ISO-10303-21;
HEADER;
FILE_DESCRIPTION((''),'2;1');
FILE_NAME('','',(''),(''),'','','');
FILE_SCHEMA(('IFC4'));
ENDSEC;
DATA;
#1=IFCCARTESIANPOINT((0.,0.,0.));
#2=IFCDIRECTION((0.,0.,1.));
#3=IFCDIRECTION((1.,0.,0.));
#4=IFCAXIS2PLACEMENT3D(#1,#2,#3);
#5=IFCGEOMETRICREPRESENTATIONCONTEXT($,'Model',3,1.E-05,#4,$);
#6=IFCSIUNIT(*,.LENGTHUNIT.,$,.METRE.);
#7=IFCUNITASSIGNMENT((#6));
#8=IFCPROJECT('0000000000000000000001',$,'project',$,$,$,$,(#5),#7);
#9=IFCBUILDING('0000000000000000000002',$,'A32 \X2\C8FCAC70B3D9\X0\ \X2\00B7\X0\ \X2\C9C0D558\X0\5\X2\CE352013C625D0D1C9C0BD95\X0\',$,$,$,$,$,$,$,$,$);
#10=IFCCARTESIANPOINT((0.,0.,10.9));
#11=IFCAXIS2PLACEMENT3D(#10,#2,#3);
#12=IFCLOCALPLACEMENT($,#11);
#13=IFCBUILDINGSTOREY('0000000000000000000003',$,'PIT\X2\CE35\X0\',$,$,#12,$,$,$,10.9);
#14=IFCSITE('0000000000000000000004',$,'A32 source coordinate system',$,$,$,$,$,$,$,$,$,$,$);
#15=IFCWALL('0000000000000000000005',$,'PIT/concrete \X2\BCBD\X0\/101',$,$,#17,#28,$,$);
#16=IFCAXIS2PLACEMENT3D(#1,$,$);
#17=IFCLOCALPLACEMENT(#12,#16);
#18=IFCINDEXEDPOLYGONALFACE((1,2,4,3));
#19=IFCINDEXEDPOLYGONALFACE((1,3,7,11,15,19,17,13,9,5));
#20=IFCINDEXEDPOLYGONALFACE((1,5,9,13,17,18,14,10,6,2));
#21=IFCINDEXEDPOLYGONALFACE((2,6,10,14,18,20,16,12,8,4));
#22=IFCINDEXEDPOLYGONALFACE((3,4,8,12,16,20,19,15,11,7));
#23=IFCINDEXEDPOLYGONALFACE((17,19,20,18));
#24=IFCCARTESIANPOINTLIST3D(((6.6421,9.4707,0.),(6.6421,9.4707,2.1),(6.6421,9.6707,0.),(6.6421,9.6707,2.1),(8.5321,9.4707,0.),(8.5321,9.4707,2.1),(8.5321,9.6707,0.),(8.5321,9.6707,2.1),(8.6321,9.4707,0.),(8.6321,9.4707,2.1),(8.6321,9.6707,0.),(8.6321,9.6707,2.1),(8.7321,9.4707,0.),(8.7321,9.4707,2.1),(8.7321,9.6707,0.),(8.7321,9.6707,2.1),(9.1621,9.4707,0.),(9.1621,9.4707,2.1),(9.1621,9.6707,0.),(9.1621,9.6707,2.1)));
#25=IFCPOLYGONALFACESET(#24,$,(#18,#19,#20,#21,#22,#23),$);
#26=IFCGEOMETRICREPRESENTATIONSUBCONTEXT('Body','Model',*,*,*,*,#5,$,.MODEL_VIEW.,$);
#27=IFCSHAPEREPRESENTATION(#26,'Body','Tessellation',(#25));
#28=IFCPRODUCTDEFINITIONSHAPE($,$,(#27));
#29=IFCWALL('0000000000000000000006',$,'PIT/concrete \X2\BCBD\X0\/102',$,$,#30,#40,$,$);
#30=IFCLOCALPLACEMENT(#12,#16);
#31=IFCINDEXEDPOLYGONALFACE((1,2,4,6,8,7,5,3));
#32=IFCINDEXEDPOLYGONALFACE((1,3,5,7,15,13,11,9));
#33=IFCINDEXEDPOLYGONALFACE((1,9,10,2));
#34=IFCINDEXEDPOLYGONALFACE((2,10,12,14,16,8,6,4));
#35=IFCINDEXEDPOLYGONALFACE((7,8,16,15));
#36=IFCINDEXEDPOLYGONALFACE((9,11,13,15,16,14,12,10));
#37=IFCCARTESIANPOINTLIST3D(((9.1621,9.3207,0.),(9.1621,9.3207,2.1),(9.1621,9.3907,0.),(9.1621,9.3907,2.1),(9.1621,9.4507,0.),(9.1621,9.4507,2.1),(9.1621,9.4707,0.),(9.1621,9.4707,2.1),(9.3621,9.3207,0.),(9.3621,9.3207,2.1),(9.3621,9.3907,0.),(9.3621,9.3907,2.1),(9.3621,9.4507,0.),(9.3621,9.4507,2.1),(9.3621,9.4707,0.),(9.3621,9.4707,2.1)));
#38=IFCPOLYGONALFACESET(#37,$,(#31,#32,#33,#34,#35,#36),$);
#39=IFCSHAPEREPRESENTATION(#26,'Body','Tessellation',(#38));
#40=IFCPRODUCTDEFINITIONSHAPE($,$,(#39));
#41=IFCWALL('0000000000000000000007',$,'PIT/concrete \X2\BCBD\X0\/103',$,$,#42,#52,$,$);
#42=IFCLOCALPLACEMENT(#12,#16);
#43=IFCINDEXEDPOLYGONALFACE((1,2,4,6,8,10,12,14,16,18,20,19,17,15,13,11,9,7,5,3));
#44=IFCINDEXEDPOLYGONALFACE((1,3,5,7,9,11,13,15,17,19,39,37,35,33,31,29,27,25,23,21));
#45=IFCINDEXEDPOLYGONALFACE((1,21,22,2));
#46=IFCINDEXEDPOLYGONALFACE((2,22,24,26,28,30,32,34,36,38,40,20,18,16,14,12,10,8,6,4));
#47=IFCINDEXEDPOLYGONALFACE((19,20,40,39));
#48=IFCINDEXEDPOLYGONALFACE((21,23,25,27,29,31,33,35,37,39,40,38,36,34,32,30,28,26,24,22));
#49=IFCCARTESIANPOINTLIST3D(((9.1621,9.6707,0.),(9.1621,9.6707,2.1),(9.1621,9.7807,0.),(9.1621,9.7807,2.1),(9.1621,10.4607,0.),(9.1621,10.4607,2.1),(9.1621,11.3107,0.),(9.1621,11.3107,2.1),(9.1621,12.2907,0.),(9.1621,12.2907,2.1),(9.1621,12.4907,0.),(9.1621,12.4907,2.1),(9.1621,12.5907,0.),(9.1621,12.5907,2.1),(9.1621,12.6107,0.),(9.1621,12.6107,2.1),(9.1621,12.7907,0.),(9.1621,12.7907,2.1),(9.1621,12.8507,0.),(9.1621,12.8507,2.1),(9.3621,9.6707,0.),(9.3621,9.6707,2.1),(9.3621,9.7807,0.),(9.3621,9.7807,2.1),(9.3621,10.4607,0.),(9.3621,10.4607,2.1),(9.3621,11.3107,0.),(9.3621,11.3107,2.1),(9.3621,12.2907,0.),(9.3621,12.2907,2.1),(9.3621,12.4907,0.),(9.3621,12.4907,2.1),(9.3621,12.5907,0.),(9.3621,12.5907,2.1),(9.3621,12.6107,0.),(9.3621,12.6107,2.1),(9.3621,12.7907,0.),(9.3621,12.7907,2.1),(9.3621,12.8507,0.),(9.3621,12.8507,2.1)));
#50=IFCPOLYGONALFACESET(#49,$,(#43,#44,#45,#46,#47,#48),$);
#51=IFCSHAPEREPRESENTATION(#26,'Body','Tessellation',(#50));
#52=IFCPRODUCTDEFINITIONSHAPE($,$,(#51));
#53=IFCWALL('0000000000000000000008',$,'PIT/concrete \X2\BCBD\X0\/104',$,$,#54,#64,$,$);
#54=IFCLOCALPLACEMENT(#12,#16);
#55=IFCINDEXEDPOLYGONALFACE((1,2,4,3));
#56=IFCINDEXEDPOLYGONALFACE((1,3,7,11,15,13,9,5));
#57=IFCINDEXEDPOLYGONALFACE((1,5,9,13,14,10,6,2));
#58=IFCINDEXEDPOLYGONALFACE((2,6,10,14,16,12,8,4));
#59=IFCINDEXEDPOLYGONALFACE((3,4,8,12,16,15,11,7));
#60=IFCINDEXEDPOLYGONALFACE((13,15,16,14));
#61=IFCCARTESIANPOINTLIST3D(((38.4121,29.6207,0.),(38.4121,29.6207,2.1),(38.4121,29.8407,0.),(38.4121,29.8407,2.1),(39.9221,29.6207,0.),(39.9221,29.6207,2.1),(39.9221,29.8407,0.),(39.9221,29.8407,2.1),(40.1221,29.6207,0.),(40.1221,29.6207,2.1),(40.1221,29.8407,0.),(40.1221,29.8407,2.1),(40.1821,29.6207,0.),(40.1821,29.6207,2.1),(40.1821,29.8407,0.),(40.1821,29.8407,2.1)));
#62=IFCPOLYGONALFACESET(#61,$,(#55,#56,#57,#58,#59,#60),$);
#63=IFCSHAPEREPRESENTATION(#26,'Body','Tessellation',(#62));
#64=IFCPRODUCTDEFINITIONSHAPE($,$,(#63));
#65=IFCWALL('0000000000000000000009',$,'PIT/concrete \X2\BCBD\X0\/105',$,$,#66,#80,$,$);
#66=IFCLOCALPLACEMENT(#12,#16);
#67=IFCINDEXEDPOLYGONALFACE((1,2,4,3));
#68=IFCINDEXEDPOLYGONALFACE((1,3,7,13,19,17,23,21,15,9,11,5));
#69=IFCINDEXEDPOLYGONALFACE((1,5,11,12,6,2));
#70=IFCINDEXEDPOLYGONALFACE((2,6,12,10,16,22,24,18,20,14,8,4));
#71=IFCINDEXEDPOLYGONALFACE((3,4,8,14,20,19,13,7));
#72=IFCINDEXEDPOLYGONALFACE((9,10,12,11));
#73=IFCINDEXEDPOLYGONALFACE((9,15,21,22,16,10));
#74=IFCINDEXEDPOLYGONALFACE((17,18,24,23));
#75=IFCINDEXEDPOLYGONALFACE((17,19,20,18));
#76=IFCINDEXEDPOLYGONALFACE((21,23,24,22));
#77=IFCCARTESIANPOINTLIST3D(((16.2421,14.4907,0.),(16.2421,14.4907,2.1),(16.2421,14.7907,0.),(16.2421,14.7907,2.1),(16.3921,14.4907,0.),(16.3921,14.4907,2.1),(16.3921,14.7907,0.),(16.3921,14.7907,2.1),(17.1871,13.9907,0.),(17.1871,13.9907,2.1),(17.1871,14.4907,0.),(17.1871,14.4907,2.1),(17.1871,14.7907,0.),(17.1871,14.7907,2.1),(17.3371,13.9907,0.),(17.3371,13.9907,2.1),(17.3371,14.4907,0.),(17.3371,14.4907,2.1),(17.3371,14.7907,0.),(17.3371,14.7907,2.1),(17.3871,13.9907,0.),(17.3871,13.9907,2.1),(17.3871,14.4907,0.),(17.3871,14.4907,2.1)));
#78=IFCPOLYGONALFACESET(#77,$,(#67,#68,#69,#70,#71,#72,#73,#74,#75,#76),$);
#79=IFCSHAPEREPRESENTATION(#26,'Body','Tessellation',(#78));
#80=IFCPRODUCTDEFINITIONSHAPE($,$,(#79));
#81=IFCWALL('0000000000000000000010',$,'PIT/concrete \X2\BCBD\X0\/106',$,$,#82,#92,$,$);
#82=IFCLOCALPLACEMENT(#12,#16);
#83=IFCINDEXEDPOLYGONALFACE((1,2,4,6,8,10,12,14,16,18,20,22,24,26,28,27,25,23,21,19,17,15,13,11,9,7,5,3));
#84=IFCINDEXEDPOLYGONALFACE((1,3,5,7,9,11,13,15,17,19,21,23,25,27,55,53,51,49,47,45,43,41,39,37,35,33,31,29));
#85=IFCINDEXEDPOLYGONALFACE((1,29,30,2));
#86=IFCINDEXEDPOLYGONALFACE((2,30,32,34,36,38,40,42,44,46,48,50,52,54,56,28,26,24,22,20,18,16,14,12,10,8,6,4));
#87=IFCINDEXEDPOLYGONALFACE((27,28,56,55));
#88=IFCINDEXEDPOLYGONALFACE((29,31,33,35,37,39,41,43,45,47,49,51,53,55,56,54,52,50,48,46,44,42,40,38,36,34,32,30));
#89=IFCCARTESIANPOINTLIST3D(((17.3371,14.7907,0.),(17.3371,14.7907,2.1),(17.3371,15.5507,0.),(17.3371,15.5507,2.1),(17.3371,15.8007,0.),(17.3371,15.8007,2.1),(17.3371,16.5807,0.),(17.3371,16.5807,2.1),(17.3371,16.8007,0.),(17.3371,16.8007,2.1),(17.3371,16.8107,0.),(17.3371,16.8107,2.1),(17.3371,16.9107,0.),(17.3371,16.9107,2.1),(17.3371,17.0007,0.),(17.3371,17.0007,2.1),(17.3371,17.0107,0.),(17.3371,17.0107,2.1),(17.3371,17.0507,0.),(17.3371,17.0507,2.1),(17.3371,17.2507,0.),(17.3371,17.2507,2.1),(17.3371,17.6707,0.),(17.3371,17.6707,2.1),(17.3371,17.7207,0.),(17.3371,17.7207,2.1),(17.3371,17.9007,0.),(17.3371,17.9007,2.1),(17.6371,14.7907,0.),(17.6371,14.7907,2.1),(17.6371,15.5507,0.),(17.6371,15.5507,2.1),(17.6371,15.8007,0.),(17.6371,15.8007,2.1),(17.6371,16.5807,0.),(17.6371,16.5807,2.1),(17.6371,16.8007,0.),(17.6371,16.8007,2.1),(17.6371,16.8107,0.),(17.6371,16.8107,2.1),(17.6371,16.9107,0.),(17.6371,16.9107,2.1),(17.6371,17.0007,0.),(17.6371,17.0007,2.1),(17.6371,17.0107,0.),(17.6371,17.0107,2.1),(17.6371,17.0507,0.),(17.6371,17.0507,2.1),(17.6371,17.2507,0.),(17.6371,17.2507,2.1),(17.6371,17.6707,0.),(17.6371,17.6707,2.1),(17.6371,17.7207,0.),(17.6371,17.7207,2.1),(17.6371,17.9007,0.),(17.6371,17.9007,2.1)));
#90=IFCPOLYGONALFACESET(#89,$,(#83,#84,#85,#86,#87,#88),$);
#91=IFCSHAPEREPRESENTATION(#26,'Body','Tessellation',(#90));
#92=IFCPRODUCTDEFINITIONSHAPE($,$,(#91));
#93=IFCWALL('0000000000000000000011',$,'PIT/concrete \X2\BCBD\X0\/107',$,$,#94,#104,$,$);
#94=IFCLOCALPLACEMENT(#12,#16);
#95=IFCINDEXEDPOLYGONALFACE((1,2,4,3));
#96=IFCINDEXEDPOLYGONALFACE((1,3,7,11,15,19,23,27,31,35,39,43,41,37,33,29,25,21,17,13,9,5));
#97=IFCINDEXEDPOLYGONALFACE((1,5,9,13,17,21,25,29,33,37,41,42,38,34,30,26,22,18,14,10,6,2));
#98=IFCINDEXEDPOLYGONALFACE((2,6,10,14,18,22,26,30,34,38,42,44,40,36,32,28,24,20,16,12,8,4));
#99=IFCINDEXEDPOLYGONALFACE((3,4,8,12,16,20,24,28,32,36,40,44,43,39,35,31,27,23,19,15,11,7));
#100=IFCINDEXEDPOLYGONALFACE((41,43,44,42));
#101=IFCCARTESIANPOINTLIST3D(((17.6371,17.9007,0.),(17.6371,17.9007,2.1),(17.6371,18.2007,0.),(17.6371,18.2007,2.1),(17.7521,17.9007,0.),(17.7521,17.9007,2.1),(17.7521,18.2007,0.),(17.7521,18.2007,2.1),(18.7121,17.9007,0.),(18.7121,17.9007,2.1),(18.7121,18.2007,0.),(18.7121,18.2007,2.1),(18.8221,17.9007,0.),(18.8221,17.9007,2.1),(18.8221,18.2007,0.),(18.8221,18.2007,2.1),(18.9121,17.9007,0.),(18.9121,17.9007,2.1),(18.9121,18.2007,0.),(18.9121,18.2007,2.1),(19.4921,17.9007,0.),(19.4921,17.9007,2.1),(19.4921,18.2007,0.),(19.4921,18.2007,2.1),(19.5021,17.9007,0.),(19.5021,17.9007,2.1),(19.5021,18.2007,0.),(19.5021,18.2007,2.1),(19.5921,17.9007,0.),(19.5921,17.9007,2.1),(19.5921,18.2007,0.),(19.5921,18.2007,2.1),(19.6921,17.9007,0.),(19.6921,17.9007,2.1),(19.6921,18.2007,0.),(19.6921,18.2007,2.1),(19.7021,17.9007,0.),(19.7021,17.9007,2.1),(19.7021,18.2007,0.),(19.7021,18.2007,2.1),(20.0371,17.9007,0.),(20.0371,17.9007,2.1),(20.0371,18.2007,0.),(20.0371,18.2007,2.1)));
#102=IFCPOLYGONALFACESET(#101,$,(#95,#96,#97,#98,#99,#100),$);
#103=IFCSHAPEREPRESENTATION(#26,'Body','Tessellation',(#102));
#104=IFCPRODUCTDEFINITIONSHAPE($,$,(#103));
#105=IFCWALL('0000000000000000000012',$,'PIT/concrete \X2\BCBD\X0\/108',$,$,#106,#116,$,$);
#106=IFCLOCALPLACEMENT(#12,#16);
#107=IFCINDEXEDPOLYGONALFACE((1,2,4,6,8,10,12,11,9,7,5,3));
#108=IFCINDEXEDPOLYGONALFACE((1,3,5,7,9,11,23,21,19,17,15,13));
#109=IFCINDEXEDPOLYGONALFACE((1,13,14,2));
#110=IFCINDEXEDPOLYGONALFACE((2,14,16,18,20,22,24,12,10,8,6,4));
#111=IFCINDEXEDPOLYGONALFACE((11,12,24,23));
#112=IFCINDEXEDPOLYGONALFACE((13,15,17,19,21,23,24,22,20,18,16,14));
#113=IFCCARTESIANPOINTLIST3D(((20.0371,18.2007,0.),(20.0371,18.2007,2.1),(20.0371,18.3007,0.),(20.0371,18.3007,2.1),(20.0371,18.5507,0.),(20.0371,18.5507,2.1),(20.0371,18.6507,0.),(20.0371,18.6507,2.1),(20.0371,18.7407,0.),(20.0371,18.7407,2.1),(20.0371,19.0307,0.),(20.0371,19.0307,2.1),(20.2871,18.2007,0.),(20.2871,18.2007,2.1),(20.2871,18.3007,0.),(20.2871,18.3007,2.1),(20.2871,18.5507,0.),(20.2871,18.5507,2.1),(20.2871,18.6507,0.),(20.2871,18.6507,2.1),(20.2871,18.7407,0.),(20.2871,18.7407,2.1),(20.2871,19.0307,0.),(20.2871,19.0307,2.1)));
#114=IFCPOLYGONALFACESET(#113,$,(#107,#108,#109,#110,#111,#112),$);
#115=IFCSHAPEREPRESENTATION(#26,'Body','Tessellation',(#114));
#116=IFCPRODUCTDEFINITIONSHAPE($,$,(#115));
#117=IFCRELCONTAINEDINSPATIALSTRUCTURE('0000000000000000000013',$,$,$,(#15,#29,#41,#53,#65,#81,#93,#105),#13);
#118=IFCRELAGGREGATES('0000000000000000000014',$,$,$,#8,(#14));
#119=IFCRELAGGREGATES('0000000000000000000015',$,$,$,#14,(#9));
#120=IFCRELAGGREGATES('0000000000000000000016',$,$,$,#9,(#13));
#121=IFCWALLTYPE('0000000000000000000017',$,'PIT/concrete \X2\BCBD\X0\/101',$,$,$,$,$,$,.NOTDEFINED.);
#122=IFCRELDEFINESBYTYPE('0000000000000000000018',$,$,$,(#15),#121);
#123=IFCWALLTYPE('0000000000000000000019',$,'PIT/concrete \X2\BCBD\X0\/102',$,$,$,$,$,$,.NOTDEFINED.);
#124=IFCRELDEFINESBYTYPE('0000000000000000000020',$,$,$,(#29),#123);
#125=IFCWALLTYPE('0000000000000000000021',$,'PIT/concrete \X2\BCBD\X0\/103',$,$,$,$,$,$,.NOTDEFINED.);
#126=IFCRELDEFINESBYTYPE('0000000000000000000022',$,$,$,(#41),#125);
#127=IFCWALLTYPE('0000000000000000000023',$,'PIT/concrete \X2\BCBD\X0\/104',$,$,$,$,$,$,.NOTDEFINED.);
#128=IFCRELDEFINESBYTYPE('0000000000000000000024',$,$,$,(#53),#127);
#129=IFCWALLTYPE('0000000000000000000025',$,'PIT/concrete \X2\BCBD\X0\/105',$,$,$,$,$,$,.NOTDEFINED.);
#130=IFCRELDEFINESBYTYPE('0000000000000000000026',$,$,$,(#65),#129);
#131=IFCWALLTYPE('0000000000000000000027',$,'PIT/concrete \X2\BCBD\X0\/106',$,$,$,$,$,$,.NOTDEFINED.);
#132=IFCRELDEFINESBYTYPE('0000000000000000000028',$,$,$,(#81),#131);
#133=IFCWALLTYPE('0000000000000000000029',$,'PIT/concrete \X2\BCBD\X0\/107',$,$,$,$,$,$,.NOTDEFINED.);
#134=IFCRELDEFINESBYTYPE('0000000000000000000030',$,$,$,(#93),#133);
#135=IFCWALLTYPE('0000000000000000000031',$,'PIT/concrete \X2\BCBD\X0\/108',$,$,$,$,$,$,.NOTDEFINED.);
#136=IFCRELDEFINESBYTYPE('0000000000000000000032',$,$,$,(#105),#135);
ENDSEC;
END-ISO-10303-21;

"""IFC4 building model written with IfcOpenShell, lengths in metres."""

from ifc_helpers import new_model, si_unit, frame, origin, origin_with_axes, place, context, subcontext, project, spatial, polyline, outline, extrude, source, transform, mapped, type_object, type_shapes, element, save


model = new_model("IFC4")

# Units and contexts
model_context = context("Model", 3, precision=1e-05, world=origin_with_axes())
body_context = subcontext(model_context, "Body", "Model", "MODEL_VIEW")
ifc_project = project(units=[si_unit("LENGTHUNIT", "METRE")], contexts=[model_context])

# Site, building, storey
site = spatial("IfcSite", under=ifc_project, Name="A32 source coordinate system")
building = spatial("IfcBuilding", under=site, Name="A32 주거동 · 지하5층–옥탑지붕")
storey_placement = place(None, frame((0.0, 0.0, 10.9), z_axis=(0.0, 0.0, 1.0), x_axis=(1.0, 0.0, 0.0)))
storey = spatial("IfcBuildingStorey", under=building, at=storey_placement, Name="PIT층", Elevation=10.9)

# Walls
wall_type_1 = type_object("IfcWallType", Name="PIT/concrete 벽/101", PredefinedType="NOTDEFINED")
shared_shape_1 = source(origin(), body_context, "Body", "SweptSolid", [
    extrude(outline(polyline([(8.7321, 9.6707), (9.1621, 9.6707), (9.1621, 9.4707), (8.7321, 9.4707), (8.6321, 9.4707), (8.5321, 9.4707), (6.6421, 9.4707), (6.6421, 9.6707), (8.5321, 9.6707), (8.6321, 9.6707), (8.7321, 9.6707)])), origin(), (0.0, 0.0, 1.0), 2.1),
])
type_shapes(wall_type_1, [shared_shape_1])
wall_1_placement = place(storey_placement, origin_with_axes())
element("IfcWall", 1, at=wall_1_placement, inside=storey, type_object=wall_type_1, Name="PIT/concrete 벽/101", context=body_context, shape_type="MappedRepresentation", body=[
    mapped(shared_shape_1, transform((0.0, 0.0, 0.0), scale=1.0)),
])
wall_type_2 = type_object("IfcWallType", Name="PIT/concrete 벽/102", PredefinedType="NOTDEFINED")
shared_shape_2 = source(origin(), body_context, "Body", "SweptSolid", [
    extrude(outline(polyline([(9.3621, 9.3907), (9.3621, 9.3207), (9.1621, 9.3207), (9.1621, 9.3907), (9.1621, 9.4507), (9.1621, 9.4707), (9.3621, 9.4707), (9.3621, 9.4507), (9.3621, 9.3907)])), origin(), (0.0, 0.0, 1.0), 2.1),
])
type_shapes(wall_type_2, [shared_shape_2])
wall_2_placement = place(storey_placement, origin_with_axes())
element("IfcWall", 2, at=wall_2_placement, inside=storey, type_object=wall_type_2, Name="PIT/concrete 벽/102", context=body_context, shape_type="MappedRepresentation", body=[
    mapped(shared_shape_2, transform((0.0, 0.0, 0.0), scale=1.0)),
])
wall_type_3 = type_object("IfcWallType", Name="PIT/concrete 벽/103", PredefinedType="NOTDEFINED")
shared_shape_3 = source(origin(), body_context, "Body", "SweptSolid", [
    extrude(outline(polyline([(9.1621, 11.3107), (9.1621, 12.2907), (9.1621, 12.4907), (9.1621, 12.5907), (9.1621, 12.6107), (9.1621, 12.7907), (9.1621, 12.8507), (9.3621, 12.8507), (9.3621, 12.7907), (9.3621, 12.6107), (9.3621, 12.5907), (9.3621, 12.4907), (9.3621, 12.2907), (9.3621, 11.3107), (9.3621, 10.4607), (9.3621, 9.7807), (9.3621, 9.6707), (9.1621, 9.6707), (9.1621, 9.7807), (9.1621, 10.4607), (9.1621, 11.3107)])), origin(), (0.0, 0.0, 1.0), 2.1),
])
type_shapes(wall_type_3, [shared_shape_3])
wall_3_placement = place(storey_placement, origin_with_axes())
element("IfcWall", 3, at=wall_3_placement, inside=storey, type_object=wall_type_3, Name="PIT/concrete 벽/103", context=body_context, shape_type="MappedRepresentation", body=[
    mapped(shared_shape_3, transform((0.0, 0.0, 0.0), scale=1.0)),
])
wall_type_4 = type_object("IfcWallType", Name="PIT/concrete 벽/104", PredefinedType="NOTDEFINED")
shared_shape_4 = source(origin(), body_context, "Body", "SweptSolid", [
    extrude(outline(polyline([(40.1821, 29.8407), (40.1821, 29.6207), (40.1221, 29.6207), (39.9221, 29.6207), (38.4121, 29.6207), (38.4121, 29.8407), (39.9221, 29.8407), (40.1221, 29.8407), (40.1821, 29.8407)])), origin(), (0.0, 0.0, 1.0), 2.1),
])
type_shapes(wall_type_4, [shared_shape_4])
wall_4_placement = place(storey_placement, origin_with_axes())
element("IfcWall", 4, at=wall_4_placement, inside=storey, type_object=wall_type_4, Name="PIT/concrete 벽/104", context=body_context, shape_type="MappedRepresentation", body=[
    mapped(shared_shape_4, transform((0.0, 0.0, 0.0), scale=1.0)),
])
wall_type_5 = type_object("IfcWallType", Name="PIT/concrete 벽/105", PredefinedType="NOTDEFINED")
shared_shape_5 = source(origin(), body_context, "Body", "SweptSolid", [
    extrude(outline(polyline([(17.3371, 14.4907), (17.3871, 14.4907), (17.3871, 13.9907), (17.3371, 13.9907), (17.1871, 13.9907), (17.1871, 14.4907), (16.3921, 14.4907), (16.2421, 14.4907), (16.2421, 14.7907), (16.3921, 14.7907), (17.1871, 14.7907), (17.3371, 14.7907), (17.3371, 14.4907)])), origin(), (0.0, 0.0, 1.0), 2.1),
])
type_shapes(wall_type_5, [shared_shape_5])
wall_5_placement = place(storey_placement, origin_with_axes())
element("IfcWall", 5, at=wall_5_placement, inside=storey, type_object=wall_type_5, Name="PIT/concrete 벽/105", context=body_context, shape_type="MappedRepresentation", body=[
    mapped(shared_shape_5, transform((0.0, 0.0, 0.0), scale=1.0)),
])
wall_type_6 = type_object("IfcWallType", Name="PIT/concrete 벽/106", PredefinedType="NOTDEFINED")
shared_shape_6 = source(origin(), body_context, "Body", "SweptSolid", [
    extrude(outline(polyline([(17.3371, 16.5807), (17.3371, 16.8007), (17.3371, 16.8107), (17.3371, 16.9107), (17.3371, 17.0007), (17.3371, 17.0107), (17.3371, 17.0507), (17.3371, 17.2507), (17.3371, 17.6707), (17.3371, 17.7207), (17.3371, 17.9007), (17.6371, 17.9007), (17.6371, 17.7207), (17.6371, 17.6707), (17.6371, 17.2507), (17.6371, 17.0507), (17.6371, 17.0107), (17.6371, 17.0007), (17.6371, 16.9107), (17.6371, 16.8107), (17.6371, 16.8007), (17.6371, 16.5807), (17.6371, 15.8007), (17.6371, 15.5507), (17.6371, 14.7907), (17.3371, 14.7907), (17.3371, 15.5507), (17.3371, 15.8007), (17.3371, 16.5807)])), origin(), (0.0, 0.0, 1.0), 2.1),
])
type_shapes(wall_type_6, [shared_shape_6])
wall_6_placement = place(storey_placement, origin_with_axes())
element("IfcWall", 6, at=wall_6_placement, inside=storey, type_object=wall_type_6, Name="PIT/concrete 벽/106", context=body_context, shape_type="MappedRepresentation", body=[
    mapped(shared_shape_6, transform((0.0, 0.0, 0.0), scale=1.0)),
])
wall_type_7 = type_object("IfcWallType", Name="PIT/concrete 벽/107", PredefinedType="NOTDEFINED")
shared_shape_7 = source(origin(), body_context, "Body", "SweptSolid", [
    extrude(outline(polyline([(18.7121, 18.2007), (18.8221, 18.2007), (18.9121, 18.2007), (19.4921, 18.2007), (19.5021, 18.2007), (19.5921, 18.2007), (19.6921, 18.2007), (19.7021, 18.2007), (20.0371, 18.2007), (20.0371, 17.9007), (19.7021, 17.9007), (19.6921, 17.9007), (19.5921, 17.9007), (19.5021, 17.9007), (19.4921, 17.9007), (18.9121, 17.9007), (18.8221, 17.9007), (18.7121, 17.9007), (17.7521, 17.9007), (17.6371, 17.9007), (17.6371, 18.2007), (17.7521, 18.2007), (18.7121, 18.2007)])), origin(), (0.0, 0.0, 1.0), 2.1),
])
type_shapes(wall_type_7, [shared_shape_7])
wall_7_placement = place(storey_placement, origin_with_axes())
element("IfcWall", 7, at=wall_7_placement, inside=storey, type_object=wall_type_7, Name="PIT/concrete 벽/107", context=body_context, shape_type="MappedRepresentation", body=[
    mapped(shared_shape_7, transform((0.0, 0.0, 0.0), scale=1.0)),
])
wall_type_8 = type_object("IfcWallType", Name="PIT/concrete 벽/108", PredefinedType="NOTDEFINED")
shared_shape_8 = source(origin(), body_context, "Body", "SweptSolid", [
    extrude(outline(polyline([(20.0371, 18.6507), (20.0371, 18.7407), (20.0371, 19.0307), (20.2871, 19.0307), (20.2871, 18.7407), (20.2871, 18.6507), (20.2871, 18.5507), (20.2871, 18.3007), (20.2871, 18.2007), (20.0371, 18.2007), (20.0371, 18.3007), (20.0371, 18.5507), (20.0371, 18.6507)])), origin(), (0.0, 0.0, 1.0), 2.1),
])
type_shapes(wall_type_8, [shared_shape_8])
wall_8_placement = place(storey_placement, origin_with_axes())
element("IfcWall", 8, at=wall_8_placement, inside=storey, type_object=wall_type_8, Name="PIT/concrete 벽/108", context=body_context, shape_type="MappedRepresentation", body=[
    mapped(shared_shape_8, transform((0.0, 0.0, 0.0), scale=1.0)),
])

save(model, "model.ifc")
